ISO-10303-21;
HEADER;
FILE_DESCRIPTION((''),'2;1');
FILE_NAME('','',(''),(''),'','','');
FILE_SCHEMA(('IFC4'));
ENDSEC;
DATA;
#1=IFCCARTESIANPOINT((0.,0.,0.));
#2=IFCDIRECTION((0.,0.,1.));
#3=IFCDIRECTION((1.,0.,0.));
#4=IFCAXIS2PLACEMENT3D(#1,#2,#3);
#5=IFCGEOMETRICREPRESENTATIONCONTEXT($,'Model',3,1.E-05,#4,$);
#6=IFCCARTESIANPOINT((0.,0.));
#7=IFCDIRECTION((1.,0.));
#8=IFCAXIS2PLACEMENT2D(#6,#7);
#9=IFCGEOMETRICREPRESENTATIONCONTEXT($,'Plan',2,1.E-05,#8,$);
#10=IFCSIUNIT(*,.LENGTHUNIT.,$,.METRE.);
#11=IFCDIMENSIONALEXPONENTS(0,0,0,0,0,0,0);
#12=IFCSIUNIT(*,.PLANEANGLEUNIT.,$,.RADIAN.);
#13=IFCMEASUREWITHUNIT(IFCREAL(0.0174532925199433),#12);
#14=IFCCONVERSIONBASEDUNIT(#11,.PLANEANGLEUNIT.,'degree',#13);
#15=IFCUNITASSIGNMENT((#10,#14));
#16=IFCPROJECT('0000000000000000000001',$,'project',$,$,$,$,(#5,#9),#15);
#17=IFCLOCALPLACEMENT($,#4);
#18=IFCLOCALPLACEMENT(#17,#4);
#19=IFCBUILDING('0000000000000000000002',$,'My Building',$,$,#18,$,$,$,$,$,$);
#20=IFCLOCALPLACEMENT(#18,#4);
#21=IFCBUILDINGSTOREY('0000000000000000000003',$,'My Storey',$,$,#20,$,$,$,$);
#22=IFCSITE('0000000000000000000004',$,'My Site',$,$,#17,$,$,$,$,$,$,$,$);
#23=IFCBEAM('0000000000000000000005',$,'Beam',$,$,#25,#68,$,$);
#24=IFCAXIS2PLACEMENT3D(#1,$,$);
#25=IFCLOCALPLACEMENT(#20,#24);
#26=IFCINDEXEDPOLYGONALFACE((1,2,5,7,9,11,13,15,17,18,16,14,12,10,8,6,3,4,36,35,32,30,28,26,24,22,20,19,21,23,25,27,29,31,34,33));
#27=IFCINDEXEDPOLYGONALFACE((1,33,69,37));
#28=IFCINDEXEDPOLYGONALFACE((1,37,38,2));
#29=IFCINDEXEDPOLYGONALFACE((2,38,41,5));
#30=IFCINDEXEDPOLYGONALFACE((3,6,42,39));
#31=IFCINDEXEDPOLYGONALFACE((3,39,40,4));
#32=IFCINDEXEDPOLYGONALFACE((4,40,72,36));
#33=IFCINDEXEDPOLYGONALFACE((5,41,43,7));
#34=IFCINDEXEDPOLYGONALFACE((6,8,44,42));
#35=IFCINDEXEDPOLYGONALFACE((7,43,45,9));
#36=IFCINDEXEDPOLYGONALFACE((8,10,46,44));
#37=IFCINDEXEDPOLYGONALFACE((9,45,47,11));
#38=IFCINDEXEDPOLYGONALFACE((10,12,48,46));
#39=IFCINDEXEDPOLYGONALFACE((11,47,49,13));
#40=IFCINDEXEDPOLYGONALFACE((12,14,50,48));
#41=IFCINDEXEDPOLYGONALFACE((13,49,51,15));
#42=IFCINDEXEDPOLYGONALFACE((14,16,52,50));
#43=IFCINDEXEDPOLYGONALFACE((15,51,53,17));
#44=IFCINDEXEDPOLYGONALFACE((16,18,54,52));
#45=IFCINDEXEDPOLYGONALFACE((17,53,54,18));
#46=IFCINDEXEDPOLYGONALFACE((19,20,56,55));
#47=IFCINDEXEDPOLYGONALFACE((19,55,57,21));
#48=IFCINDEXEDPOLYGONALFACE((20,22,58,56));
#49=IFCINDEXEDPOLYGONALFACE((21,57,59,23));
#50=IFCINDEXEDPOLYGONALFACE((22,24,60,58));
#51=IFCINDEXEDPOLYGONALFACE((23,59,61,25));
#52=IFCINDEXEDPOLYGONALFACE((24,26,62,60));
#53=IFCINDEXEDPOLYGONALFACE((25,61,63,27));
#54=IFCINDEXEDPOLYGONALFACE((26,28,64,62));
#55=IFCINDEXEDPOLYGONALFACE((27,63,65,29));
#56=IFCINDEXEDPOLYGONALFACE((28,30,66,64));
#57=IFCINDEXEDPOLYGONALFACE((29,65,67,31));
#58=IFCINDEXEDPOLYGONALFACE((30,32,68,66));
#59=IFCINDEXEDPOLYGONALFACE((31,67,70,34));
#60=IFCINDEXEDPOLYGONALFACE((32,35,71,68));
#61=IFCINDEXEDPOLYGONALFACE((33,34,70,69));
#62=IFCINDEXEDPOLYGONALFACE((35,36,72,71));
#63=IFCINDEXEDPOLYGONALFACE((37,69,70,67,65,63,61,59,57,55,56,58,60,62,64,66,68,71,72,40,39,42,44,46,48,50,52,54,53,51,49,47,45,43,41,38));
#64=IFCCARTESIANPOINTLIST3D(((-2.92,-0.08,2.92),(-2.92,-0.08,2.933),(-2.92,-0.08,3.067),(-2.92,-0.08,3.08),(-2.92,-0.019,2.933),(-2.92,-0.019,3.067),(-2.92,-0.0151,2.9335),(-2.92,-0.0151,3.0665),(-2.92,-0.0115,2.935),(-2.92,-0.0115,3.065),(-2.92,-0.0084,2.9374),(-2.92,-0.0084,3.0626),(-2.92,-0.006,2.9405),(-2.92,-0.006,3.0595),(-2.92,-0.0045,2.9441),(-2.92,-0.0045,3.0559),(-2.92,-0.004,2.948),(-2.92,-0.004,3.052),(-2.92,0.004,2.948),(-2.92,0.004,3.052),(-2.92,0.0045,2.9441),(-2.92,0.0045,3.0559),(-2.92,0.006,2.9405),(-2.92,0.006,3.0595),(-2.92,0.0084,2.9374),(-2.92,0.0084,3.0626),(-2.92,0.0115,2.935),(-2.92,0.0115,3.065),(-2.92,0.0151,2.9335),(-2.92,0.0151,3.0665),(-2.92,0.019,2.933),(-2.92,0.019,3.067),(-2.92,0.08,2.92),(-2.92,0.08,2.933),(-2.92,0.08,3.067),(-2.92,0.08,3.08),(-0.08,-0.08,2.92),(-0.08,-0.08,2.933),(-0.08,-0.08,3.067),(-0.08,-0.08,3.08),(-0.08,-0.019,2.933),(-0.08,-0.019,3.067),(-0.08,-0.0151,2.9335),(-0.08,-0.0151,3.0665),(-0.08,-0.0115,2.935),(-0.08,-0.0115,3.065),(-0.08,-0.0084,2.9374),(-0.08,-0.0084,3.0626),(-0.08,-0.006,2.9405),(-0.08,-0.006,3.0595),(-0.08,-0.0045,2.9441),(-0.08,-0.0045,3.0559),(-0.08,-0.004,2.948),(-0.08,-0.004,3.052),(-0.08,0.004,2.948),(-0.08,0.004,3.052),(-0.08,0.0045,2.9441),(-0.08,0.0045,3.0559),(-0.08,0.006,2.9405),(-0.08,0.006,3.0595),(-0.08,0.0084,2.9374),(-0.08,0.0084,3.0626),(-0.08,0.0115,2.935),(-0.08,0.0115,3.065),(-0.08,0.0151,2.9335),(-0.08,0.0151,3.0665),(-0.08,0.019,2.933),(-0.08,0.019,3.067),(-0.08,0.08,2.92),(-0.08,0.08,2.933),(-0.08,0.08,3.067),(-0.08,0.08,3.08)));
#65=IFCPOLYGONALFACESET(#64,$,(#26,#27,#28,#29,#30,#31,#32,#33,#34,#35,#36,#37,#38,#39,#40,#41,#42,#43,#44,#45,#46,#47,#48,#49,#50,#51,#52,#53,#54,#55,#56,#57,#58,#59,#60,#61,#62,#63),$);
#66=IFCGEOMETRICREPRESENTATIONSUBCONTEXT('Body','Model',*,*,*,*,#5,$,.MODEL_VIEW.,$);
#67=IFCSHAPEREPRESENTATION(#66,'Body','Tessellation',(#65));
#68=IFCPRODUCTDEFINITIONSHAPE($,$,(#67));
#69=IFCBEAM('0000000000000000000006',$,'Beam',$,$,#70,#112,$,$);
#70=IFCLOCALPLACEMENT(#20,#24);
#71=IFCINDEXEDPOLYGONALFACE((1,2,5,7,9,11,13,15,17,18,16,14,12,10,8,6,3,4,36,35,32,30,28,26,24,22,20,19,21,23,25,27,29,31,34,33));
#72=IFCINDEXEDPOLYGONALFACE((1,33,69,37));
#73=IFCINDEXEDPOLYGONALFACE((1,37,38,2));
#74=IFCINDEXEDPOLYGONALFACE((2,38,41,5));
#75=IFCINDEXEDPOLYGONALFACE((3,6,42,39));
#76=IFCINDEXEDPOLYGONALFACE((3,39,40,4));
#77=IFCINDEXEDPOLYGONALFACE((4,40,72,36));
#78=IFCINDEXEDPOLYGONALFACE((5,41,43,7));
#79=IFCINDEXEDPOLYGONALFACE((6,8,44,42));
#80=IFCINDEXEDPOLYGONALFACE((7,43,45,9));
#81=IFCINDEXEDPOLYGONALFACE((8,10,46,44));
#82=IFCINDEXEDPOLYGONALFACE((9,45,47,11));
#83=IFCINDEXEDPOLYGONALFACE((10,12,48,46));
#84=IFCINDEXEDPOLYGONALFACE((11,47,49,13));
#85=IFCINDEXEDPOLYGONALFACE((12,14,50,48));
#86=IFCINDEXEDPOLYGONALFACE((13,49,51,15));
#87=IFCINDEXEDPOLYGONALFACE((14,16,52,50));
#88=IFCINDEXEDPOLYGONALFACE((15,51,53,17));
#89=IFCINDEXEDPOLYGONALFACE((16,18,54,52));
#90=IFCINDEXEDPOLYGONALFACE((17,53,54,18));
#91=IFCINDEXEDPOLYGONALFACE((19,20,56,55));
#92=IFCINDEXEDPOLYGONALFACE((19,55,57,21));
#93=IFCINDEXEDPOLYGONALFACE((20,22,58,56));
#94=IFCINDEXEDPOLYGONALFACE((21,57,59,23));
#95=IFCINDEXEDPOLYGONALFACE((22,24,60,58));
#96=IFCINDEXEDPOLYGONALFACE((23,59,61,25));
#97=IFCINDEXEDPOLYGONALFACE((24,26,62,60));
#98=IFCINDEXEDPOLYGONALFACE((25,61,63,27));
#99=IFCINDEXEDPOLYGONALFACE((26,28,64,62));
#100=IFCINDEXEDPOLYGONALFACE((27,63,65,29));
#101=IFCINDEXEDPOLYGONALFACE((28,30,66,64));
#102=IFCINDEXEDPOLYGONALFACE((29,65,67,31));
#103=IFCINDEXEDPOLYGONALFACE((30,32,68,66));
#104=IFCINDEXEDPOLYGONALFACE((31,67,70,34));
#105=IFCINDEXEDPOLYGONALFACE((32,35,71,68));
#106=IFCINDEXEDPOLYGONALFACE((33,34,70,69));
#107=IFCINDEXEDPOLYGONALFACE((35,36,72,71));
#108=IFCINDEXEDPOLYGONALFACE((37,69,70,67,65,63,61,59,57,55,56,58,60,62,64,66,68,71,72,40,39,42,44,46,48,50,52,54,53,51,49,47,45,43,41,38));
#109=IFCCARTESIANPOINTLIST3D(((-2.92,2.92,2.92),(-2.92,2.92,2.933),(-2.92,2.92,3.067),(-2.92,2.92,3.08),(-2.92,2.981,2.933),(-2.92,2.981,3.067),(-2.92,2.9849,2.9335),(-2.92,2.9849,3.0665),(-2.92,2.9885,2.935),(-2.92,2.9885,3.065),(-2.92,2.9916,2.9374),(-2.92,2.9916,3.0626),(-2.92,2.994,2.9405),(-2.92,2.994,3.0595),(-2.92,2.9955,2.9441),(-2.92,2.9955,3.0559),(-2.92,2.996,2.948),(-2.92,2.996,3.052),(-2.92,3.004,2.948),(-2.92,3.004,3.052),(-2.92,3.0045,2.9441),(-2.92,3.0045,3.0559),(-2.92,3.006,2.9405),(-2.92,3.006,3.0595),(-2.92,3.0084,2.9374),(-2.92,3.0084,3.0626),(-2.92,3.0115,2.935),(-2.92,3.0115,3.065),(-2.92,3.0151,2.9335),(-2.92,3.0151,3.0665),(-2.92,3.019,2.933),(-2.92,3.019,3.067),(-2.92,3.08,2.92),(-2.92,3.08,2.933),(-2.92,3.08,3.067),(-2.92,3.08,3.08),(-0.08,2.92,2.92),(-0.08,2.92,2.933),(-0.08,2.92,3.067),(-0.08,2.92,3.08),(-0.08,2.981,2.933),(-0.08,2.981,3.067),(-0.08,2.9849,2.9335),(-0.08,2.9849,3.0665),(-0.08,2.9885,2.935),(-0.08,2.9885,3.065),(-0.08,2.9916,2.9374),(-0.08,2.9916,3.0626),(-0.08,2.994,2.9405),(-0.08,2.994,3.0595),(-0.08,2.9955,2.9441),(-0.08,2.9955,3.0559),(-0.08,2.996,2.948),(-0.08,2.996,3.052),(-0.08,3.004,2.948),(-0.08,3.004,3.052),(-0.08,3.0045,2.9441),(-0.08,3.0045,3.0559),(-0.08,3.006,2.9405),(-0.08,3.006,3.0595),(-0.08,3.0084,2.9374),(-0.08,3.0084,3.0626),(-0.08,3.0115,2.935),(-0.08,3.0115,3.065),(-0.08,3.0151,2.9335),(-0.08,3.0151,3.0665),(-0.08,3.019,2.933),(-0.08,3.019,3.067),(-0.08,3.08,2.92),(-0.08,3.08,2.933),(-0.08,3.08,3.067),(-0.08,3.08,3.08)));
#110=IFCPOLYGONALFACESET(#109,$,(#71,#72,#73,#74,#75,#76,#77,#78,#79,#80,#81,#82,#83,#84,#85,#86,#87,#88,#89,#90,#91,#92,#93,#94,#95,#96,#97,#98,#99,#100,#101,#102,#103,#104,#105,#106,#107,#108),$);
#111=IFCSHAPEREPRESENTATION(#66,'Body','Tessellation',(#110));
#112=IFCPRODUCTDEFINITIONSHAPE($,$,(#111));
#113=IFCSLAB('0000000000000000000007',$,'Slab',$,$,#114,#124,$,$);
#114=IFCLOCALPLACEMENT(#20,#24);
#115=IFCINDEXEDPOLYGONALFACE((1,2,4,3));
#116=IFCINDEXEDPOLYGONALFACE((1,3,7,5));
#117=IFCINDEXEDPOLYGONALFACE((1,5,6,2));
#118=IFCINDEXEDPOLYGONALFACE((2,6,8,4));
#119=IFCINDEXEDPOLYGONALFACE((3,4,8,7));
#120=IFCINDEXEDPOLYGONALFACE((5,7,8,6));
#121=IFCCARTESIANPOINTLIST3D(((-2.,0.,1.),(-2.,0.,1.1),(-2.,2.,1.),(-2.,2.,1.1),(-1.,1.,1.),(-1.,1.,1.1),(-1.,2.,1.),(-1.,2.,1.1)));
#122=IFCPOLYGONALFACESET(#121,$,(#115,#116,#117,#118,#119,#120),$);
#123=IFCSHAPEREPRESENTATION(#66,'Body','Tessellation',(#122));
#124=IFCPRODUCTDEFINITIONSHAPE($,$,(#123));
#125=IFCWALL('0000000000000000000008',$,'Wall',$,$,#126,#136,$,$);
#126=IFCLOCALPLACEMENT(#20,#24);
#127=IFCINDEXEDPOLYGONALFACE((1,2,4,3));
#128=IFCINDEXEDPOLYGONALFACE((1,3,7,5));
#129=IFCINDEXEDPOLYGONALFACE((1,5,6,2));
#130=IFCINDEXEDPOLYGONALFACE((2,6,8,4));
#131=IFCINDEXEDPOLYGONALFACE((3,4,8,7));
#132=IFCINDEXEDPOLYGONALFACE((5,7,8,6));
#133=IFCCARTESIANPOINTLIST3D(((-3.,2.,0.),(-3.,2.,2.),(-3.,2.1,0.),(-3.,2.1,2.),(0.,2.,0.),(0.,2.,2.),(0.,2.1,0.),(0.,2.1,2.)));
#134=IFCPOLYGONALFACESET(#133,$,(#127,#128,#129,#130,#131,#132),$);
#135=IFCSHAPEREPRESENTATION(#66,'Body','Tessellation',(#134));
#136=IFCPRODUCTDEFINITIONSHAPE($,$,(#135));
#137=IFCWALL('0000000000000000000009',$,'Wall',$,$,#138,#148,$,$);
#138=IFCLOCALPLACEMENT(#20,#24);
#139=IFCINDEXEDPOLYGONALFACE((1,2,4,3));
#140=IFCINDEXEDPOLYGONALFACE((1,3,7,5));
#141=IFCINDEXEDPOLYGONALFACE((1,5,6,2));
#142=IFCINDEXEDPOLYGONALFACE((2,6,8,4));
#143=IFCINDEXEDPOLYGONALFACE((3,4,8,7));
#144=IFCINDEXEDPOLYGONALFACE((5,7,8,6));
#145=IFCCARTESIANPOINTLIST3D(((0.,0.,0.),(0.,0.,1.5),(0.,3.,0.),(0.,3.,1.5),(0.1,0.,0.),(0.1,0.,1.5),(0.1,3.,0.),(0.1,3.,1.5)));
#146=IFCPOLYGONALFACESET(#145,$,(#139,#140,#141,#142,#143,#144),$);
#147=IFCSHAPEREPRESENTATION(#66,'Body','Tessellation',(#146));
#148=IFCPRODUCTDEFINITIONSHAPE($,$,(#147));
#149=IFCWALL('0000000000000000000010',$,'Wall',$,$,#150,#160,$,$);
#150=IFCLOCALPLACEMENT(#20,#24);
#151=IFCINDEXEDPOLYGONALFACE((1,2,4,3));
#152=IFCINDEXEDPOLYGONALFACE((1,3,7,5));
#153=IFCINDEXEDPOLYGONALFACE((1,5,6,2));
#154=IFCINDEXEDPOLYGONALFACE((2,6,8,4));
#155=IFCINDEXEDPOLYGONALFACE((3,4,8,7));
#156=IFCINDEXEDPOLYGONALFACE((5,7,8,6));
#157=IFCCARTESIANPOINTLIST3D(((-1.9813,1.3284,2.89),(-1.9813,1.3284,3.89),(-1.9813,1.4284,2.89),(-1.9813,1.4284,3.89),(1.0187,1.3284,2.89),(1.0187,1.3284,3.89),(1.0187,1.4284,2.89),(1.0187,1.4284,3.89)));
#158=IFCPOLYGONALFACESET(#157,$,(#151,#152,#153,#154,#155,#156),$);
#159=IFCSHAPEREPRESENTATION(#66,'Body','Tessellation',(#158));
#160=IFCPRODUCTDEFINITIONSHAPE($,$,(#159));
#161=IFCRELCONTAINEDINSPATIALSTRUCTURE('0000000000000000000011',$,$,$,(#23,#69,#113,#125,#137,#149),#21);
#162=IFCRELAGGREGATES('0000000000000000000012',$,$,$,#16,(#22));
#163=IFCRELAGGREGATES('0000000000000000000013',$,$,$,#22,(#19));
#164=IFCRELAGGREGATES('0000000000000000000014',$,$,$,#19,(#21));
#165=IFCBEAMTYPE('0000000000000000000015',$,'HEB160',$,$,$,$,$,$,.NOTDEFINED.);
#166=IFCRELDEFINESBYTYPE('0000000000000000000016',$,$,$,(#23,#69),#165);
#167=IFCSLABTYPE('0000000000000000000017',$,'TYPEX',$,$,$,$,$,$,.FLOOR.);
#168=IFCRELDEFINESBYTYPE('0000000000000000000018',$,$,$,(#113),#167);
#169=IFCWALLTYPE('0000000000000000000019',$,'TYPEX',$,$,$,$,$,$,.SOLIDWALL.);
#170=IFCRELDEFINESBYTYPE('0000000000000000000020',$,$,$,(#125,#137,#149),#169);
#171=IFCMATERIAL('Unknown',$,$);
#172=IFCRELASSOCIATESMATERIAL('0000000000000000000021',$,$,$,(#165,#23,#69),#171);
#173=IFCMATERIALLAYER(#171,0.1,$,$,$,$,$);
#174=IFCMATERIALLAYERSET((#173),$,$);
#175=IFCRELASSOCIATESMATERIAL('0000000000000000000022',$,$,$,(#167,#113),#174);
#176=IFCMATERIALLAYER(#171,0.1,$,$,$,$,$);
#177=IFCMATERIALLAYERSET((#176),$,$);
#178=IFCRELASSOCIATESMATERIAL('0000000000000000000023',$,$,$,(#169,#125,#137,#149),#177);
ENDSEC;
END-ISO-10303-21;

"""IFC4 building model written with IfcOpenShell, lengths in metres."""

from ifc_helpers import new_model, entity, si_unit, converted_unit, frame, origin_with_axes, origin_2d_with_axis, place, context, subcontext, project, spatial, line, indexed_curve, i_section, outline, extrude, material, layer, layer_set, layer_usage, material_profile, profile_set, profile_usage, type_object, element, save


model = new_model("IFC4")

# Units and contexts
model_context = context("Model", 3, precision=1e-05, world=origin_with_axes())
plan_context = context("Plan", 2, precision=1e-05, world=origin_2d_with_axis())
body_context = subcontext(model_context, "Body", "Model", "MODEL_VIEW")
ifc_project = project(units=[si_unit("LENGTHUNIT", "METRE"), converted_unit("PLANEANGLEUNIT", "degree", entity("IfcReal", 0.0174532925199433), si_unit("PLANEANGLEUNIT", "RADIAN"), dimensions=[0, 0, 0, 0, 0, 0, 0])], contexts=[model_context, plan_context])

# Site, building, storey
site_placement = place(None, origin_with_axes())
site = spatial("IfcSite", under=ifc_project, at=site_placement, Name="My Site")
building_placement = place(site_placement, origin_with_axes())
building = spatial("IfcBuilding", under=site, at=building_placement, Name="My Building")
storey_placement = place(building_placement, origin_with_axes())
storey = spatial("IfcBuildingStorey", under=building, at=storey_placement, Name="My Storey")

# Shared definitions
ifc_material = material(Name="Unknown")

# Beams
ifc_material_profile_1 = material_profile(ifc_material, i_section(OverallWidth=0.16, OverallDepth=0.16, WebThickness=0.008, FlangeThickness=0.013, FilletRadius=0.015))
ifc_profile_set_1 = profile_set([ifc_material_profile_1])
beam_type_1 = type_object("IfcBeamType", Name="HEB160", PredefinedType="NOTDEFINED", material=ifc_profile_set_1)
ifc_profile_usage_1 = profile_usage(ifc_profile_set_1, cardinal=5)
beam_1_placement = place(storey_placement, frame((-2.92, 0.0, 3.0), z_axis=(1.0, 0.0, 0.0), x_axis=(0.0, 1.0, 0.0)))
element("IfcBeam", 1, at=beam_1_placement, inside=storey, type_object=beam_type_1, material=ifc_profile_usage_1, Name="Beam", context=body_context, shape_type="SweptSolid", body=[
    extrude(i_section(OverallWidth=0.16, OverallDepth=0.16, WebThickness=0.008, FlangeThickness=0.013, FilletRadius=0.015), origin_with_axes(), (0.0, 0.0, 1.0), 2.84),
])
ifc_profile_usage_2 = profile_usage(ifc_profile_set_1, cardinal=5)
beam_2_placement = place(storey_placement, frame((-2.92, 3.0, 3.0), z_axis=(1.0, 0.0, 0.0), x_axis=(0.0, 1.0, 0.0)))
element("IfcBeam", 2, at=beam_2_placement, inside=storey, type_object=beam_type_1, material=ifc_profile_usage_2, Name="Beam", context=body_context, shape_type="SweptSolid", body=[
    extrude(i_section(OverallWidth=0.16, OverallDepth=0.16, WebThickness=0.008, FlangeThickness=0.013, FilletRadius=0.015), origin_with_axes(), (0.0, 0.0, 1.0), 2.84),
])

# Slab
ifc_layer_1 = layer(ifc_material, 0.1)
ifc_layer_set_1 = layer_set([ifc_layer_1])
slab_type = type_object("IfcSlabType", Name="TYPEX", PredefinedType="FLOOR", material=ifc_layer_set_1)
ifc_layer_usage_1 = layer_usage(ifc_layer_set_1, "AXIS3", "POSITIVE", 0.0)
slab_1_placement = place(storey_placement, frame((-2.0, 1.0, 1.0), z_axis=(0.0, 0.0, 1.0), x_axis=(1.0, 0.0, 0.0)))
element("IfcSlab", 3, at=slab_1_placement, inside=storey, type_object=slab_type, material=ifc_layer_usage_1, Name="Slab", context=body_context, shape_type="SweptSolid", body=[
    extrude(outline(indexed_curve([(0.0, -1.0), (1.0, 0.0), (1.0, 1.0), (0.0, 1.0)], segments=[line(3, 2), line(2, 1), line(1, 4), line(4, 3)], self_intersect=False)), None, (0.0, 0.0, 1.0), 0.1),
])

# Walls
ifc_layer_2 = layer(ifc_material, 0.1)
ifc_layer_set_2 = layer_set([ifc_layer_2])
ifc_layer_usage_2 = layer_usage(ifc_layer_set_2, "AXIS2", "POSITIVE", 0.0)
wall_type = type_object("IfcWallType", Name="TYPEX", PredefinedType="SOLIDWALL", material=ifc_layer_set_2)
wall_1_placement = place(storey_placement, frame((-3.0, 2.0, 0.0), z_axis=(0.0, 0.0, 1.0), x_axis=(1.0, 0.0, 0.0)))
element("IfcWall", 4, at=wall_1_placement, inside=storey, type_object=wall_type, material=ifc_layer_usage_2, Name="Wall", context=body_context, shape_type="SweptSolid", body=[
    extrude(outline(indexed_curve([(0.0, 0.0), (0.0, 0.1), (3.0, 0.1), (3.0, 0.0), (0.0, 0.0)], self_intersect=False)), origin_with_axes(), (0.0, 0.0, 1.0), 2.0),
])
ifc_layer_usage_3 = layer_usage(ifc_layer_set_2, "AXIS2", "POSITIVE", 0.0)
wall_2_placement = place(storey_placement, frame((0.0, 3.0, 0.0), z_axis=(0.0, 0.0, 1.0), x_axis=(-0.000001, -1.0, 0.0)))
element("IfcWall", 5, at=wall_2_placement, inside=storey, type_object=wall_type, material=ifc_layer_usage_3, Name="Wall", context=body_context, shape_type="SweptSolid", body=[
    extrude(outline(indexed_curve([(0.0, 0.0), (0.0, 0.1), (3.0, 0.1), (3.0, 0.0), (0.0, 0.0)], self_intersect=False)), origin_with_axes(), (0.0, 0.0, 1.0), 1.5),
])
ifc_layer_usage_4 = layer_usage(ifc_layer_set_2, "AXIS2", "POSITIVE", 0.0)
wall_3_placement = place(storey_placement, frame((-1.9813, 1.3284, 2.89), z_axis=(0.0, 0.0, 1.0), x_axis=(1.0, 0.0, 0.0)))
element("IfcWall", 6, at=wall_3_placement, inside=storey, type_object=wall_type, material=ifc_layer_usage_4, Name="Wall", context=body_context, shape_type="SweptSolid", body=[
    extrude(outline(indexed_curve([(0.0, 0.0), (0.0, 0.1), (3.0, 0.1), (3.0, 0.0), (0.0, 0.0)], self_intersect=False)), origin_with_axes(), (0.0, 0.0, 1.0), 1.0),
])

save(model, "model.ifc")
